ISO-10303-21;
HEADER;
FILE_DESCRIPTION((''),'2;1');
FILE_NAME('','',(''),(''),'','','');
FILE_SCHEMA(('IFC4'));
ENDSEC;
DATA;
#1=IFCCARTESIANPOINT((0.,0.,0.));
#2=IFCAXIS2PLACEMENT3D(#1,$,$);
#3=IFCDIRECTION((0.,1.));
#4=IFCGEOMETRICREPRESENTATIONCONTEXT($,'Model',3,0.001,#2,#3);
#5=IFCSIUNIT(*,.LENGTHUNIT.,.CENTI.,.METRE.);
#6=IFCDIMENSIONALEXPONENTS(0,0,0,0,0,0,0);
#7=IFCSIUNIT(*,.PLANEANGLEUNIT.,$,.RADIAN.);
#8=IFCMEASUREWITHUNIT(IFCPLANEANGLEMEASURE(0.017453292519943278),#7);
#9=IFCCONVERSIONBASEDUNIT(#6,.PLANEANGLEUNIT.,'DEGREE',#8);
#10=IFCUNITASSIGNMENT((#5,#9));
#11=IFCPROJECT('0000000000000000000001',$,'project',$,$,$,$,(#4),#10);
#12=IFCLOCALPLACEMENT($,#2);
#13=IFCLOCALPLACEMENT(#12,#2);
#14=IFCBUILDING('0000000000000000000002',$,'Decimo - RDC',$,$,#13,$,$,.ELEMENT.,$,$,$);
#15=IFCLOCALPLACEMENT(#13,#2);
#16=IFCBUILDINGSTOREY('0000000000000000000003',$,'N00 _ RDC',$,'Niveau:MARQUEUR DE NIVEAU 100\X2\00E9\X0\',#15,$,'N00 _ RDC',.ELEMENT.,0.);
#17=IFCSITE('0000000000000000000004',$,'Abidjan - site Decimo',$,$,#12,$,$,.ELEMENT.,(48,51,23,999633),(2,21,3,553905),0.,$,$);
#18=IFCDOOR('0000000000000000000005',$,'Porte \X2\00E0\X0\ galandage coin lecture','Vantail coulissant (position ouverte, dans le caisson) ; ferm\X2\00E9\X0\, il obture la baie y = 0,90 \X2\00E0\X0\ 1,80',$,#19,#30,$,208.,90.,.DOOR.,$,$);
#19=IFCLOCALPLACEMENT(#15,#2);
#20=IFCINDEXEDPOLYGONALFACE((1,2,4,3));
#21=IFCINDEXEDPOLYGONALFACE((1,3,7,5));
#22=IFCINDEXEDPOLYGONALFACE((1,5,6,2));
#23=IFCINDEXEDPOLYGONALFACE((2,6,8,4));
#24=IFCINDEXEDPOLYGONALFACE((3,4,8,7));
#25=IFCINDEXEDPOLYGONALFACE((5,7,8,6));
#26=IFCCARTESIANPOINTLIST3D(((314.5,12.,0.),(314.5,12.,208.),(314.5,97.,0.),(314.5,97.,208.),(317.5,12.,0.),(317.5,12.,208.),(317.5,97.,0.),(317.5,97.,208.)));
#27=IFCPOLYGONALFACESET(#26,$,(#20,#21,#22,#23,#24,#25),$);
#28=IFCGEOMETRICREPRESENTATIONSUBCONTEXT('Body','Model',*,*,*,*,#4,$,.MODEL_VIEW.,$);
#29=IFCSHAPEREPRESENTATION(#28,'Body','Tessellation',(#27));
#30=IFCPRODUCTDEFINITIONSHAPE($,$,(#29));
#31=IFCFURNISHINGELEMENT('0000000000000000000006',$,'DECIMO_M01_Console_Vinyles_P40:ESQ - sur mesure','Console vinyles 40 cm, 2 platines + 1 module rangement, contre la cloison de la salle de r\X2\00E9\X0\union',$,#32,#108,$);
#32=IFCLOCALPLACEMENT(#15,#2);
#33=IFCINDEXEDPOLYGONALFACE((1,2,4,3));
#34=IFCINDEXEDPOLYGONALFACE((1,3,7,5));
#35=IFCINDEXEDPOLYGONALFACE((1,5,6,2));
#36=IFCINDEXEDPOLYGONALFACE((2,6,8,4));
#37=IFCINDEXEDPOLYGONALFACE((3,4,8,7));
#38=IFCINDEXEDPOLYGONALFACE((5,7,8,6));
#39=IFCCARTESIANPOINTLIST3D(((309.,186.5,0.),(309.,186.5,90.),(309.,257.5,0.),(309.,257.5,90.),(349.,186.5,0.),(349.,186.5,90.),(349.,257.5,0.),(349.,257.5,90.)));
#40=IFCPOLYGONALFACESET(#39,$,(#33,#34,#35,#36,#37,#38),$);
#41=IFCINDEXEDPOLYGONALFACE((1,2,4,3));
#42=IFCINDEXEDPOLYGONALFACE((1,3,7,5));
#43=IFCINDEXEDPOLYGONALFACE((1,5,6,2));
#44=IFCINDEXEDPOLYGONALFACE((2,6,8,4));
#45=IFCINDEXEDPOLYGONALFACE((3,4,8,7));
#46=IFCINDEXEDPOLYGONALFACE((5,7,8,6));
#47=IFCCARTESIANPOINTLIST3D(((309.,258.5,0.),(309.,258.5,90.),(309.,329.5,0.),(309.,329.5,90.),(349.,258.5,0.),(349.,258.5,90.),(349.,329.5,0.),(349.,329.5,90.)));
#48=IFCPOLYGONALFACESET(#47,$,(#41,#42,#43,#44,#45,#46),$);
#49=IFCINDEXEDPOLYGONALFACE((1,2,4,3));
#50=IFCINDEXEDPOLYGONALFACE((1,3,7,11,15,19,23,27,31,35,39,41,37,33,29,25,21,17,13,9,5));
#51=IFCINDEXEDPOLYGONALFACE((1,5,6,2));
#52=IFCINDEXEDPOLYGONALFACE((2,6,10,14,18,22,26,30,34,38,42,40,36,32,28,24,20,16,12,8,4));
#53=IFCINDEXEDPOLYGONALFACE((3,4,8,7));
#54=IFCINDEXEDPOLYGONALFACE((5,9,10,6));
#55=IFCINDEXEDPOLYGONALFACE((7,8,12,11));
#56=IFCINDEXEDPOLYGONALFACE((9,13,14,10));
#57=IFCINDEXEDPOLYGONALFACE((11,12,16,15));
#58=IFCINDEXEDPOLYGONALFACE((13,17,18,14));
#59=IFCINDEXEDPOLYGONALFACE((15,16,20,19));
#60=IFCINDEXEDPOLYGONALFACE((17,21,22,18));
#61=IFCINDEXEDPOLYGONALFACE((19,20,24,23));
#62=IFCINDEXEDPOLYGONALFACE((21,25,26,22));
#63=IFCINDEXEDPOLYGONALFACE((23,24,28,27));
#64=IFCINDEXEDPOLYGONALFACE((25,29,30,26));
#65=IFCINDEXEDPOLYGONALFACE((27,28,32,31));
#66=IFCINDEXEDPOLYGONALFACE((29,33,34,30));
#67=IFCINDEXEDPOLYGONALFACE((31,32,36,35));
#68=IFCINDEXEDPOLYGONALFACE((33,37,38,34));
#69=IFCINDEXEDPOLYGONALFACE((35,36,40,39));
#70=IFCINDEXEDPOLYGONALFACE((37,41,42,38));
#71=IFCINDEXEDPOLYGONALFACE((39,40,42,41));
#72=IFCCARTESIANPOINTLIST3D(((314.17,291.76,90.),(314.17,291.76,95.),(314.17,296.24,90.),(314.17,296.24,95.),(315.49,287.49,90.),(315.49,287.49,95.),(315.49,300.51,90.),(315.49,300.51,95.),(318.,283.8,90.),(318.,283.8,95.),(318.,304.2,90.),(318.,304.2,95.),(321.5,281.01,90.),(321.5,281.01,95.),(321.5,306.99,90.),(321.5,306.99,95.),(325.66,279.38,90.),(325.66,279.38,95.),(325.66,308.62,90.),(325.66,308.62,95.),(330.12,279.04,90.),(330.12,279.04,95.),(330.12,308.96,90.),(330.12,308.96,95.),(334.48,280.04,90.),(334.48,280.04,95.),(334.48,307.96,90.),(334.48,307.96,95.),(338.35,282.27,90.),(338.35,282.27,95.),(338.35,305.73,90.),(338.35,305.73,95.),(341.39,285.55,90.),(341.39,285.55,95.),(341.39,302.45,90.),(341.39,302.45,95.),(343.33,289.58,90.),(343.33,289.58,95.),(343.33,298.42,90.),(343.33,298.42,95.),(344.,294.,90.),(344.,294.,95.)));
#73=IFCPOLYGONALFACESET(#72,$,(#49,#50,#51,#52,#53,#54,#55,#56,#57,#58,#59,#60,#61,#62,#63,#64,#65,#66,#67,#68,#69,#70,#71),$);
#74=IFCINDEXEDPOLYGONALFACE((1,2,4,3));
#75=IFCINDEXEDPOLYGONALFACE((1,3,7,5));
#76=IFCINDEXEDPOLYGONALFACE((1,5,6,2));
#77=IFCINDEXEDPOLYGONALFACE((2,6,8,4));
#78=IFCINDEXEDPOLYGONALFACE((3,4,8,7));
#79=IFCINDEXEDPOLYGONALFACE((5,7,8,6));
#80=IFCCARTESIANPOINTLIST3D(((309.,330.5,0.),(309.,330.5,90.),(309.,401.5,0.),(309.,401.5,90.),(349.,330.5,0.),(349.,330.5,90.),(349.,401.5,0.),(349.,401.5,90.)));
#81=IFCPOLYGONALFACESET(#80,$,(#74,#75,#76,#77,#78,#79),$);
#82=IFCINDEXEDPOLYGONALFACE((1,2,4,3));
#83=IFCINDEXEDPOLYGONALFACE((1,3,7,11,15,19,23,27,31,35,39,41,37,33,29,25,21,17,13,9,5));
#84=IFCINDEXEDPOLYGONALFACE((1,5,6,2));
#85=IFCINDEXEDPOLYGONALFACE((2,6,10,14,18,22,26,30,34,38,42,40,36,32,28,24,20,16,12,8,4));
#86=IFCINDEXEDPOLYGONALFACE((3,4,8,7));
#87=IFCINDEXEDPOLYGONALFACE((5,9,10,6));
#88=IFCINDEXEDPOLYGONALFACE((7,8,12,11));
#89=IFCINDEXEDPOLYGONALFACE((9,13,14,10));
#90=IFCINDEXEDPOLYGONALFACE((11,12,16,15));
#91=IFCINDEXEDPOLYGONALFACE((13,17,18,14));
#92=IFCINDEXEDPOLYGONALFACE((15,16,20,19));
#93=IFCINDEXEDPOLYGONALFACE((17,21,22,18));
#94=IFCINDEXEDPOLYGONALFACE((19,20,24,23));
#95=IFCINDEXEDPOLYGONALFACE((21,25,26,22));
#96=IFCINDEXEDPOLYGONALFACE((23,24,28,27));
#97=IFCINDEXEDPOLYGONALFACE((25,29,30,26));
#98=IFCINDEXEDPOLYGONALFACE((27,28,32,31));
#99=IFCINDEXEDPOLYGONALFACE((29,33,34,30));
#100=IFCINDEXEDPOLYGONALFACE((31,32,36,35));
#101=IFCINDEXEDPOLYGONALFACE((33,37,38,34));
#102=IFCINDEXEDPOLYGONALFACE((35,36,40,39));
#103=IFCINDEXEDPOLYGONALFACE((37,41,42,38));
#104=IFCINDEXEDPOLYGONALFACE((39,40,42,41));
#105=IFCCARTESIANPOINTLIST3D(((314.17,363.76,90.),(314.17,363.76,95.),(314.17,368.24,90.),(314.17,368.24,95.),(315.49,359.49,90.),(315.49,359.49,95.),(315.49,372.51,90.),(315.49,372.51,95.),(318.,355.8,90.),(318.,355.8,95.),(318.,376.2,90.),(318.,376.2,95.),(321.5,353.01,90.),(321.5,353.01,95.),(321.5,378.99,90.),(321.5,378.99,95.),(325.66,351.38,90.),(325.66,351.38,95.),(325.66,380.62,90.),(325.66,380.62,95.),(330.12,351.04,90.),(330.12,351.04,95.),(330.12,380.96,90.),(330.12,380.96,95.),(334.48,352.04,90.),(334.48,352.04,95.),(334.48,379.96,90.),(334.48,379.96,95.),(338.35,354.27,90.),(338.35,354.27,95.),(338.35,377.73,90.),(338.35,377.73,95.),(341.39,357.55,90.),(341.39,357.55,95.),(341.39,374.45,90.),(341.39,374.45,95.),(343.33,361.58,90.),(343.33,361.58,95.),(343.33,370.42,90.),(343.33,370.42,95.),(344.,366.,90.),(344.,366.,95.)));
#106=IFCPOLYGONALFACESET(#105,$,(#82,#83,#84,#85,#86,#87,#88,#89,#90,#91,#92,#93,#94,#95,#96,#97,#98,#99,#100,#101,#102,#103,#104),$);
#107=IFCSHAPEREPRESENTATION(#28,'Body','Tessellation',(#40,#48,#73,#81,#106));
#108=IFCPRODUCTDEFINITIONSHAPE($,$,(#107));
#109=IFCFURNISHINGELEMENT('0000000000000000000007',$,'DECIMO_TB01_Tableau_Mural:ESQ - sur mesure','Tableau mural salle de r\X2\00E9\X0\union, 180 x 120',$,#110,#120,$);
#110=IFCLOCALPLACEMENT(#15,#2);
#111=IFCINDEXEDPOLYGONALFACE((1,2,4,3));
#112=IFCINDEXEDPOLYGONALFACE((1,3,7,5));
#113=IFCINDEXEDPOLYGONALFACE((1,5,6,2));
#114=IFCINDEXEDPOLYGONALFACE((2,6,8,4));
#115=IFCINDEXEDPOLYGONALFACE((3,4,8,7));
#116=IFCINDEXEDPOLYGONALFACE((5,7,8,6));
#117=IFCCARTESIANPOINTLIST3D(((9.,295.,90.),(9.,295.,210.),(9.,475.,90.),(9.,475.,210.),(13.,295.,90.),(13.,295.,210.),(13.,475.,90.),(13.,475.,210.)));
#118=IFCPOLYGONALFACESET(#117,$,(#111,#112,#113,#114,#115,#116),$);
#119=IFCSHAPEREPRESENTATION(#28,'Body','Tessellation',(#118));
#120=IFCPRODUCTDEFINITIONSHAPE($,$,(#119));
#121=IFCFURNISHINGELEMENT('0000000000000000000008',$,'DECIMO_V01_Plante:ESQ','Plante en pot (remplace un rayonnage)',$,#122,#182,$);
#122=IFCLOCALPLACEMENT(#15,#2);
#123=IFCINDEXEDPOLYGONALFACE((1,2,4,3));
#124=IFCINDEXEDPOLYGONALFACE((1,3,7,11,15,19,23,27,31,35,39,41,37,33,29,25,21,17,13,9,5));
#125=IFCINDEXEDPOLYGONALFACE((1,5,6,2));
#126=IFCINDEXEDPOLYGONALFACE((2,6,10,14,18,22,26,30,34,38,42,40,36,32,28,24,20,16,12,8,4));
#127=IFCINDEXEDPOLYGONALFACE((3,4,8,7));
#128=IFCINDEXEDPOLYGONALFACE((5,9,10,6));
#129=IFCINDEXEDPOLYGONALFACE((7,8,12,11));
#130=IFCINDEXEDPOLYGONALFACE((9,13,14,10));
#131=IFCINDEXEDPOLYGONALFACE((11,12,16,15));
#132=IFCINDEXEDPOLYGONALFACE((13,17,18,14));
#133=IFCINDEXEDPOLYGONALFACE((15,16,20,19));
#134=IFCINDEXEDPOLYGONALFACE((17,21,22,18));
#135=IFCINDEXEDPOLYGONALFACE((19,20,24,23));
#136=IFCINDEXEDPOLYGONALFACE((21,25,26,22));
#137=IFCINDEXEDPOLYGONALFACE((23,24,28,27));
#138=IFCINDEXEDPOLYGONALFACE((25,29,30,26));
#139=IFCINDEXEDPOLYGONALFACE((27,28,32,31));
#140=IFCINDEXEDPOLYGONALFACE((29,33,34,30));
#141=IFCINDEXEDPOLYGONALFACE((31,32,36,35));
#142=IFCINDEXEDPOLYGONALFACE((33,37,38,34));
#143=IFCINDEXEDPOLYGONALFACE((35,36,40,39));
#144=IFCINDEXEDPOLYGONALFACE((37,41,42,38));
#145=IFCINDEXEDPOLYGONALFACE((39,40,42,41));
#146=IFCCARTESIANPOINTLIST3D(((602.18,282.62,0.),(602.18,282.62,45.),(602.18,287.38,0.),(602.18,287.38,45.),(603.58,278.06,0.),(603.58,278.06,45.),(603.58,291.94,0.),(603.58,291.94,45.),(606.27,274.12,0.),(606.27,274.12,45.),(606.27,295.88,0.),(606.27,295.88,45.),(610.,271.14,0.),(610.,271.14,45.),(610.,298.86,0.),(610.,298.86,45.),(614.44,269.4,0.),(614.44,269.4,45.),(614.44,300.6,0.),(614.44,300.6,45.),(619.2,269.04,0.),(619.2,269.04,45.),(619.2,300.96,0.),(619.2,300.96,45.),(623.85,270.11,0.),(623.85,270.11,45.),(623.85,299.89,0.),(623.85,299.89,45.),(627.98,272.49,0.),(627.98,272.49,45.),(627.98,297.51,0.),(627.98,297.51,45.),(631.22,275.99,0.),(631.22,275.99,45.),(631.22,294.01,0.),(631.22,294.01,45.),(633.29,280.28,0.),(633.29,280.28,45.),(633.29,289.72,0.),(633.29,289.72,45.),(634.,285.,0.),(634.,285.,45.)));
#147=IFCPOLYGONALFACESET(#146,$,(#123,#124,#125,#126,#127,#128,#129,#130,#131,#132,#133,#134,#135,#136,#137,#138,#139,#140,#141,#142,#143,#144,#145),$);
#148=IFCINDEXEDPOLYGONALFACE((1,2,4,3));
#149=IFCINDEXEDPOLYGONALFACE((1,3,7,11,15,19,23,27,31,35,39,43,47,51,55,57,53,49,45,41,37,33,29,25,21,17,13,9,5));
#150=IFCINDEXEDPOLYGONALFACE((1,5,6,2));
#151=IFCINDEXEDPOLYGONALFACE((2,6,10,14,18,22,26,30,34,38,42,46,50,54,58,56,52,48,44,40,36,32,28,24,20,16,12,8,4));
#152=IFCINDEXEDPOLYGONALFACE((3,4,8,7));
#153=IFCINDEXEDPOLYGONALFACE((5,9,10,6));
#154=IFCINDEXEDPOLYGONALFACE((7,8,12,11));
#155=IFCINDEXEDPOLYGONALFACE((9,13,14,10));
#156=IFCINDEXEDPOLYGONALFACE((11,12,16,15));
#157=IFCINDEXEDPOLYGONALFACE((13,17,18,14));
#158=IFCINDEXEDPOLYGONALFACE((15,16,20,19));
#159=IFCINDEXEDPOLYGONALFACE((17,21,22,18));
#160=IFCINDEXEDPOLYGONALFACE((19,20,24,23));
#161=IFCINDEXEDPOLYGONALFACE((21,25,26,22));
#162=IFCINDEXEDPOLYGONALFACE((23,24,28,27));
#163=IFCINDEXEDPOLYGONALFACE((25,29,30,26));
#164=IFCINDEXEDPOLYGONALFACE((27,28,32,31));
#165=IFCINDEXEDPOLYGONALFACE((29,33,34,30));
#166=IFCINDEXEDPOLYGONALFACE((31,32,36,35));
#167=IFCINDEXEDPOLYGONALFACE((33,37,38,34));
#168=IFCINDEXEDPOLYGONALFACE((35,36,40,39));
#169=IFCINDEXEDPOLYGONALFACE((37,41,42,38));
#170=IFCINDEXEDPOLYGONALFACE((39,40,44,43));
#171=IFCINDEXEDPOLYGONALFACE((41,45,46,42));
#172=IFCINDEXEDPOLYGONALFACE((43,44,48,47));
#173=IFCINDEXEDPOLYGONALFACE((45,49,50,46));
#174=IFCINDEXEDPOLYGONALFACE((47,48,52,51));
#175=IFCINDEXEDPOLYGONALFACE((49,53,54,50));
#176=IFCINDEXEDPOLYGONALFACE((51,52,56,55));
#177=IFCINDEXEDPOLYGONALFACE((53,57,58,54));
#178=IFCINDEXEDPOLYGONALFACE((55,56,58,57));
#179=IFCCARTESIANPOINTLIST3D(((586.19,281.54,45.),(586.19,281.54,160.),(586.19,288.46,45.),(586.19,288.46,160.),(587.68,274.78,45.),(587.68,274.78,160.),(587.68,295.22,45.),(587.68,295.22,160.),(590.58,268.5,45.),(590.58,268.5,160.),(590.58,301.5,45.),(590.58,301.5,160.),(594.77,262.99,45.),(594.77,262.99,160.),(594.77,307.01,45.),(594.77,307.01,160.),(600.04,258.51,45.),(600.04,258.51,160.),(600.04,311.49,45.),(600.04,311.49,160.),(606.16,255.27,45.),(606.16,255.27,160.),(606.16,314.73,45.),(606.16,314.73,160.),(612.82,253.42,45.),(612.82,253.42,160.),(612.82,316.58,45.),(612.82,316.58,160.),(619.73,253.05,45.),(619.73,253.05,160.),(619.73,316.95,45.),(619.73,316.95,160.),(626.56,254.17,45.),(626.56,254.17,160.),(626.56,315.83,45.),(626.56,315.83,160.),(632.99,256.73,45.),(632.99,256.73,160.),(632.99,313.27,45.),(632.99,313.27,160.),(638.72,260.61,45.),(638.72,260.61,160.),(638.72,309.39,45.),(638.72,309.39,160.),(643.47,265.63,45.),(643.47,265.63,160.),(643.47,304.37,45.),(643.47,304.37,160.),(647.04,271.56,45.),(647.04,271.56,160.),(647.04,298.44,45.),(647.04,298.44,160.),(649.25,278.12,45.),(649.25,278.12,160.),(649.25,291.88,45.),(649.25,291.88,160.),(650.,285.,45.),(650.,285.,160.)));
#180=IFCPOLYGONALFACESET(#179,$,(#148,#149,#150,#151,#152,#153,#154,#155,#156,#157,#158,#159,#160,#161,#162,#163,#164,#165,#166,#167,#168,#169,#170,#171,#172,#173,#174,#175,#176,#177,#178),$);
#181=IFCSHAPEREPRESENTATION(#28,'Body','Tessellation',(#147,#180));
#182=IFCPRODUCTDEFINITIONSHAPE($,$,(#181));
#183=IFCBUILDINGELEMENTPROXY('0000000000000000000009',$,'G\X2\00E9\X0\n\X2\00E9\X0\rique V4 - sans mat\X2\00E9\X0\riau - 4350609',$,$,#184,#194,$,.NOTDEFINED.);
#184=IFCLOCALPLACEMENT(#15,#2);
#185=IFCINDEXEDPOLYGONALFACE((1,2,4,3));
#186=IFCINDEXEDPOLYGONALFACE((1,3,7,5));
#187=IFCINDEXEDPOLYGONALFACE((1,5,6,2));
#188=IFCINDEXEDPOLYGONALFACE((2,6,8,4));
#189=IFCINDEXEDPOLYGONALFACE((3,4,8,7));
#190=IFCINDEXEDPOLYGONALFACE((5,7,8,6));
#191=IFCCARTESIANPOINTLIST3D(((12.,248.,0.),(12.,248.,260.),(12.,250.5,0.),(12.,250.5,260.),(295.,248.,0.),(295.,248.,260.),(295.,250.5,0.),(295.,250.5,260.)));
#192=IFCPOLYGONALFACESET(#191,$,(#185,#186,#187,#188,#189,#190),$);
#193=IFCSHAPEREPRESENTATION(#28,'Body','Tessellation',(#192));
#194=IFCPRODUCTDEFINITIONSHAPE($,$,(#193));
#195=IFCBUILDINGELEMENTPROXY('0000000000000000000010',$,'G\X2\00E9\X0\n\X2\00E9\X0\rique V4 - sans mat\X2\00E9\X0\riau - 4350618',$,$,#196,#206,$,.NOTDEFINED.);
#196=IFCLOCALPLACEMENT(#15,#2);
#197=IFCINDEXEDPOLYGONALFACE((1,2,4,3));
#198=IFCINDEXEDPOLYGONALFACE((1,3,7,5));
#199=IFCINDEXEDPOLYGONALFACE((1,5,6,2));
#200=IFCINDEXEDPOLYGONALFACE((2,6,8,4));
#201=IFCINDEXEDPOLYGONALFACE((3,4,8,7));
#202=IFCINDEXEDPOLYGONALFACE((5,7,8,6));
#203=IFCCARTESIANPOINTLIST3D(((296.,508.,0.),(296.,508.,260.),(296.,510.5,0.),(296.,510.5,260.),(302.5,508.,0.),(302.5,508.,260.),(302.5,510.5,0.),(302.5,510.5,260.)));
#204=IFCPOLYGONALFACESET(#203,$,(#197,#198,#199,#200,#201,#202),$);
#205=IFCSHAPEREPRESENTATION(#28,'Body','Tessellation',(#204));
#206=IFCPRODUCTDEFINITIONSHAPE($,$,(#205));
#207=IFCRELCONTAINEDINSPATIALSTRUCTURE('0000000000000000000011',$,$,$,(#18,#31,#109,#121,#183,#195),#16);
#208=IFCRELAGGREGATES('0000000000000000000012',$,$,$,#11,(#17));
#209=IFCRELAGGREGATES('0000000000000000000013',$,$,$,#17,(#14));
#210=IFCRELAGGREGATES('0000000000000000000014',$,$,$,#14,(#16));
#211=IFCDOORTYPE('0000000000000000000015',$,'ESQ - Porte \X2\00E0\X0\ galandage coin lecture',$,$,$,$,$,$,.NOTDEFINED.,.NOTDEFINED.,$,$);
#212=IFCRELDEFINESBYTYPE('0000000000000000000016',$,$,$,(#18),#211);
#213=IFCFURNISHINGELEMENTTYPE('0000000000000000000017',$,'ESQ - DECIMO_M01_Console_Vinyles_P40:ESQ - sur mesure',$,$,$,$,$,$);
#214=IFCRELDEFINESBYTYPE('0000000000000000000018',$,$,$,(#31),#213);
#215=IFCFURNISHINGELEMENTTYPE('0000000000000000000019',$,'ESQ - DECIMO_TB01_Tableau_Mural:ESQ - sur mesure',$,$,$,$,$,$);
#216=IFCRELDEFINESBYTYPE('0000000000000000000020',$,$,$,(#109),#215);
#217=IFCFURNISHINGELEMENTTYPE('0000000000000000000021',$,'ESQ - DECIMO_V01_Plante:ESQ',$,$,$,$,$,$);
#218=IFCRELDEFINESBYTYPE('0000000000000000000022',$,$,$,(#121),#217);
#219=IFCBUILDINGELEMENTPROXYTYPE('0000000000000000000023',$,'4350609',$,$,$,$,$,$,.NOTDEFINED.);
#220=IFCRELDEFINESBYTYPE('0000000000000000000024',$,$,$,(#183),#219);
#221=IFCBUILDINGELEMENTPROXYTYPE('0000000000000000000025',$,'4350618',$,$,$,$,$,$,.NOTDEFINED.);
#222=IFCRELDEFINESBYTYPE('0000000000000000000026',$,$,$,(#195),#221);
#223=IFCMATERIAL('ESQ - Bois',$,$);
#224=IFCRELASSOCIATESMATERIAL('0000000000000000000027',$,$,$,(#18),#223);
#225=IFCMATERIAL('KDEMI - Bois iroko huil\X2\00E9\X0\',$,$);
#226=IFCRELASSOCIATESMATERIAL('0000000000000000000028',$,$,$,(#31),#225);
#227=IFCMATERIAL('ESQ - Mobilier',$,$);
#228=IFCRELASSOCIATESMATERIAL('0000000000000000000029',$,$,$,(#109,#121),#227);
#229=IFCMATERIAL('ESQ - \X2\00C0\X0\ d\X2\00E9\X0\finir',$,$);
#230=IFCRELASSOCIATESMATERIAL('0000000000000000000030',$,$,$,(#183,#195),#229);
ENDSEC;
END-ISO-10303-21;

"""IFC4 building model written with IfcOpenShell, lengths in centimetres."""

from ifc_helpers import new_model, entity, si_unit, converted_unit, direction, frame, frame_2d, origin, origin_with_axes, place, context, subcontext, project, spatial, rectangle, circle, extrude, material, type_object, element, save


model = new_model("IFC4")

# Units and contexts
model_context = context("Model", 3, precision=0.001, world=origin(), true_north=direction((0.0, 1.0)))
body_context = subcontext(model_context, "Body", "Model", "MODEL_VIEW")
ifc_project = project(units=[si_unit("LENGTHUNIT", "METRE", prefix="CENTI"), converted_unit("PLANEANGLEUNIT", "DEGREE", entity("IfcPlaneAngleMeasure", 0.017453292519943278), si_unit("PLANEANGLEUNIT", "RADIAN"), dimensions=[0, 0, 0, 0, 0, 0, 0])], contexts=[model_context])

# Site, building, storey
site_placement = place(None, origin())
site = spatial("IfcSite", under=ifc_project, at=site_placement, Name="Abidjan - site Decimo", CompositionType="ELEMENT", RefLatitude=(48, 51, 23, 999633), RefLongitude=(2, 21, 3, 553905), RefElevation=0.0)
building_placement = place(site_placement, origin())
building = spatial("IfcBuilding", under=site, at=building_placement, Name="Decimo - RDC", CompositionType="ELEMENT")
storey_placement = place(building_placement, origin())
storey = spatial("IfcBuildingStorey", under=building, at=storey_placement, Name="N00 _ RDC", ObjectType="Niveau:MARQUEUR DE NIVEAU 100é", LongName="N00 _ RDC", CompositionType="ELEMENT", Elevation=0.0)

# Door
ifc_material_1 = material(Name="ESQ - Bois")
door_type = type_object("IfcDoorType", Name="ESQ - Porte à galandage coin lecture", OperationType="NOTDEFINED", PredefinedType="NOTDEFINED")
door_placement = place(storey_placement, origin_with_axes())
element("IfcDoor", 1, at=door_placement, inside=storey, type_object=door_type, material=ifc_material_1, Name="Porte à galandage coin lecture", Description="Vantail coulissant (position ouverte, dans le caisson) ; fermé, il obture la baie y = 0,90 à 1,80", OverallHeight=208.0, OverallWidth=90.0, PredefinedType="DOOR", context=body_context, shape_type="SweptSolid", body=[
    extrude(rectangle(XDim=3.0, YDim=85.0, at=frame_2d((316.0, 54.5))), origin(), (0.0, 0.0, 1.0), 208.0),
])

# Furnishing elements
ifc_material_2 = material(Name="KDEMI - Bois iroko huilé")
furnishing_element_type_1 = type_object("IfcFurnishingElementType", Name="ESQ - DECIMO_M01_Console_Vinyles_P40:ESQ - sur mesure")
furnishing_1_placement = place(storey_placement, origin_with_axes())
element("IfcFurnishingElement", 2, at=furnishing_1_placement, inside=storey, type_object=furnishing_element_type_1, material=ifc_material_2, Name="DECIMO_M01_Console_Vinyles_P40:ESQ - sur mesure", Description="Console vinyles 40 cm, 2 platines + 1 module rangement, contre la cloison de la salle de réunion", context=body_context, shape_type="SweptSolid", body=[
    extrude(rectangle(XDim=40.0, YDim=71.0, at=frame_2d((329.0, 222.0))), origin(), (0.0, 0.0, 1.0), 90.0),
    extrude(rectangle(XDim=40.0, YDim=71.0, at=frame_2d((329.0, 294.0))), origin(), (0.0, 0.0, 1.0), 90.0),
    extrude(circle(Radius=15.0, at=frame_2d((329.0, 294.0))), frame((0.0, 0.0, 90.0)), (0.0, 0.0, 1.0), 5.0),
    extrude(rectangle(XDim=40.0, YDim=71.0, at=frame_2d((329.0, 366.0))), origin(), (0.0, 0.0, 1.0), 90.0),
    extrude(circle(Radius=15.0, at=frame_2d((329.0, 366.0))), frame((0.0, 0.0, 90.0)), (0.0, 0.0, 1.0), 5.0),
])
ifc_material_3 = material(Name="ESQ - Mobilier")
furnishing_element_type_2 = type_object("IfcFurnishingElementType", Name="ESQ - DECIMO_TB01_Tableau_Mural:ESQ - sur mesure")
furnishing_2_placement = place(storey_placement, origin_with_axes())
element("IfcFurnishingElement", 3, at=furnishing_2_placement, inside=storey, type_object=furnishing_element_type_2, material=ifc_material_3, Name="DECIMO_TB01_Tableau_Mural:ESQ - sur mesure", Description="Tableau mural salle de réunion, 180 x 120", context=body_context, shape_type="SweptSolid", body=[
    extrude(rectangle(XDim=4.0, YDim=180.0, at=frame_2d((11.0, 385.0))), frame((0.0, 0.0, 90.0)), (0.0, 0.0, 1.0), 120.0),
])
furnishing_element_type_3 = type_object("IfcFurnishingElementType", Name="ESQ - DECIMO_V01_Plante:ESQ")
furnishing_3_placement = place(storey_placement, origin_with_axes())
element("IfcFurnishingElement", 4, at=furnishing_3_placement, inside=storey, type_object=furnishing_element_type_3, material=ifc_material_3, Name="DECIMO_V01_Plante:ESQ", Description="Plante en pot (remplace un rayonnage)", context=body_context, shape_type="SweptSolid", body=[
    extrude(circle(Radius=16.0, at=frame_2d((618.0, 285.0))), origin(), (0.0, 0.0, 1.0), 45.0),
    extrude(circle(Radius=32.0, at=frame_2d((618.0, 285.0))), frame((0.0, 0.0, 45.0)), (0.0, 0.0, 1.0), 115.0),
])

# Building element proxies
ifc_material_4 = material(Name="ESQ - À définir")
building_element_proxy_type_1 = type_object("IfcBuildingElementProxyType", Name="4350609", PredefinedType="NOTDEFINED")
proxy_1_placement = place(storey_placement, origin())
element("IfcBuildingElementProxy", 5, at=proxy_1_placement, inside=storey, type_object=building_element_proxy_type_1, material=ifc_material_4, Name="Générique V4 - sans matériau - 4350609", PredefinedType="NOTDEFINED", context=body_context, shape_type="SweptSolid", body=[
    extrude(rectangle(XDim=283.0, YDim=2.5, at=frame_2d((0.0, 0.0), x_axis=(1.0, 0.0))), frame((153.5, 249.25, 0.0)), (0.0, 0.0, 1.0), 260.0),
])
building_element_proxy_type_2 = type_object("IfcBuildingElementProxyType", Name="4350618", PredefinedType="NOTDEFINED")
proxy_2_placement = place(storey_placement, origin())
element("IfcBuildingElementProxy", 6, at=proxy_2_placement, inside=storey, type_object=building_element_proxy_type_2, material=ifc_material_4, Name="Générique V4 - sans matériau - 4350618", PredefinedType="NOTDEFINED", context=body_context, shape_type="SweptSolid", body=[
    extrude(rectangle(XDim=6.5, YDim=2.5, at=frame_2d((0.0, 0.0), x_axis=(1.0, 0.0))), frame((299.25, 509.25, 0.0)), (0.0, 0.0, 1.0), 260.0),
])

save(model, "model.ifc")
